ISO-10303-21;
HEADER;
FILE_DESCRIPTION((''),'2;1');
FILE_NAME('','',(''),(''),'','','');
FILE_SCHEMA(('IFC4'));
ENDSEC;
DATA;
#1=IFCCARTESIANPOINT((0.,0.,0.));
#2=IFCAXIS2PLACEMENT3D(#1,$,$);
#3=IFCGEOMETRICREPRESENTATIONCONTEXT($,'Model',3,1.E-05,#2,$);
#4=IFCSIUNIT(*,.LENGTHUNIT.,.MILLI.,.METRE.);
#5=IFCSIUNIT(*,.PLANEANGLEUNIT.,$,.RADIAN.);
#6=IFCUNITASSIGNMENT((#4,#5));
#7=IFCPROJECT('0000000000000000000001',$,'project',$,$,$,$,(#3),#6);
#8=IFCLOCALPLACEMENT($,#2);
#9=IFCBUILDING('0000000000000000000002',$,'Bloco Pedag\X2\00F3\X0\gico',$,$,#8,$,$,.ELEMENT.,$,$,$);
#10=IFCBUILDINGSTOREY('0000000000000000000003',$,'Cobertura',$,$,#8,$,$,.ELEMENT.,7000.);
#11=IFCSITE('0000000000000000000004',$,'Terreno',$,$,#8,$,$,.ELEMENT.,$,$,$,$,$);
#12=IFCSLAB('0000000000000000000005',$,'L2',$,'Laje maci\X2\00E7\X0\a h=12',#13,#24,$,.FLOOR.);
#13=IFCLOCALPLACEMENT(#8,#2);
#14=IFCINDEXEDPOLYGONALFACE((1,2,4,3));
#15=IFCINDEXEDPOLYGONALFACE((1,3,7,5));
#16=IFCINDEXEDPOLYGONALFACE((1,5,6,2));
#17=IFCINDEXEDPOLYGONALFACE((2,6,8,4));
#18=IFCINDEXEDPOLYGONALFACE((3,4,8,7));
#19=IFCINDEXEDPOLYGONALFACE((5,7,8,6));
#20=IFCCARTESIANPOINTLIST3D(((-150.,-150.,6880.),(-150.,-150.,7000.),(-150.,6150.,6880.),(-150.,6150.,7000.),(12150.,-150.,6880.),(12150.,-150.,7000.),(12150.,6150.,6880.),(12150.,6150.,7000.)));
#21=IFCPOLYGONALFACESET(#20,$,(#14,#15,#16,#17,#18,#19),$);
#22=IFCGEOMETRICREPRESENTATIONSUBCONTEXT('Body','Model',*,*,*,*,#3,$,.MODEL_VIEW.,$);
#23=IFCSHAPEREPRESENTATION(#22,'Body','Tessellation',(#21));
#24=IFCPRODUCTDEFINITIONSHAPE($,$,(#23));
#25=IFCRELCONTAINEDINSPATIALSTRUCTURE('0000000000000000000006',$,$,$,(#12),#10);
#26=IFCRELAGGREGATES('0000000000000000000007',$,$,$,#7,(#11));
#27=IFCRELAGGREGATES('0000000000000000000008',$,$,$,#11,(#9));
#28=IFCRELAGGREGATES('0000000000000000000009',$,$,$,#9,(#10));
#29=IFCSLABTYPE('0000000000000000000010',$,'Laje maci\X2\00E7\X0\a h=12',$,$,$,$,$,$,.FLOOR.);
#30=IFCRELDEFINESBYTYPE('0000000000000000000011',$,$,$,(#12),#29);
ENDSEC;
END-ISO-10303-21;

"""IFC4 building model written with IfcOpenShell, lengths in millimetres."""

from ifc_helpers import new_model, si_unit, frame, origin, origin_2d, place, context, subcontext, project, spatial, rectangle, extrude, type_object, element, save


model = new_model("IFC4")

# Units and contexts
model_context = context("Model", 3, precision=1e-05, world=origin())
body_context = subcontext(model_context, "Body", "Model", "MODEL_VIEW")
ifc_project = project(units=[si_unit("LENGTHUNIT", "METRE", prefix="MILLI"), si_unit("PLANEANGLEUNIT", "RADIAN")], contexts=[model_context])

# Site, building, storey
placement = place(None, origin())
site = spatial("IfcSite", under=ifc_project, at=placement, Name="Terreno", CompositionType="ELEMENT")
building = spatial("IfcBuilding", under=site, at=placement, Name="Bloco Pedagógico", CompositionType="ELEMENT")
storey = spatial("IfcBuildingStorey", under=building, at=placement, Name="Cobertura", CompositionType="ELEMENT", Elevation=7000.0)

# Slab
slab_type = type_object("IfcSlabType", Name="Laje maciça h=12", PredefinedType="FLOOR")
slab_placement = place(None, frame((6000.0, 3000.0, 6880.0), z_axis=(0.0, 0.0, 1.0), x_axis=(1.0, 0.0, 0.0)))
element("IfcSlab", 1, at=slab_placement, inside=storey, type_object=slab_type, Name="L2", ObjectType="Laje maciça h=12", PredefinedType="FLOOR", context=body_context, shape_type="SweptSolid", body=[
    extrude(rectangle(XDim=12300.0, YDim=6300.0, at=origin_2d()), None, (0.0, 0.0, 1.0), 120.0),
])

save(model, "model.ifc")
